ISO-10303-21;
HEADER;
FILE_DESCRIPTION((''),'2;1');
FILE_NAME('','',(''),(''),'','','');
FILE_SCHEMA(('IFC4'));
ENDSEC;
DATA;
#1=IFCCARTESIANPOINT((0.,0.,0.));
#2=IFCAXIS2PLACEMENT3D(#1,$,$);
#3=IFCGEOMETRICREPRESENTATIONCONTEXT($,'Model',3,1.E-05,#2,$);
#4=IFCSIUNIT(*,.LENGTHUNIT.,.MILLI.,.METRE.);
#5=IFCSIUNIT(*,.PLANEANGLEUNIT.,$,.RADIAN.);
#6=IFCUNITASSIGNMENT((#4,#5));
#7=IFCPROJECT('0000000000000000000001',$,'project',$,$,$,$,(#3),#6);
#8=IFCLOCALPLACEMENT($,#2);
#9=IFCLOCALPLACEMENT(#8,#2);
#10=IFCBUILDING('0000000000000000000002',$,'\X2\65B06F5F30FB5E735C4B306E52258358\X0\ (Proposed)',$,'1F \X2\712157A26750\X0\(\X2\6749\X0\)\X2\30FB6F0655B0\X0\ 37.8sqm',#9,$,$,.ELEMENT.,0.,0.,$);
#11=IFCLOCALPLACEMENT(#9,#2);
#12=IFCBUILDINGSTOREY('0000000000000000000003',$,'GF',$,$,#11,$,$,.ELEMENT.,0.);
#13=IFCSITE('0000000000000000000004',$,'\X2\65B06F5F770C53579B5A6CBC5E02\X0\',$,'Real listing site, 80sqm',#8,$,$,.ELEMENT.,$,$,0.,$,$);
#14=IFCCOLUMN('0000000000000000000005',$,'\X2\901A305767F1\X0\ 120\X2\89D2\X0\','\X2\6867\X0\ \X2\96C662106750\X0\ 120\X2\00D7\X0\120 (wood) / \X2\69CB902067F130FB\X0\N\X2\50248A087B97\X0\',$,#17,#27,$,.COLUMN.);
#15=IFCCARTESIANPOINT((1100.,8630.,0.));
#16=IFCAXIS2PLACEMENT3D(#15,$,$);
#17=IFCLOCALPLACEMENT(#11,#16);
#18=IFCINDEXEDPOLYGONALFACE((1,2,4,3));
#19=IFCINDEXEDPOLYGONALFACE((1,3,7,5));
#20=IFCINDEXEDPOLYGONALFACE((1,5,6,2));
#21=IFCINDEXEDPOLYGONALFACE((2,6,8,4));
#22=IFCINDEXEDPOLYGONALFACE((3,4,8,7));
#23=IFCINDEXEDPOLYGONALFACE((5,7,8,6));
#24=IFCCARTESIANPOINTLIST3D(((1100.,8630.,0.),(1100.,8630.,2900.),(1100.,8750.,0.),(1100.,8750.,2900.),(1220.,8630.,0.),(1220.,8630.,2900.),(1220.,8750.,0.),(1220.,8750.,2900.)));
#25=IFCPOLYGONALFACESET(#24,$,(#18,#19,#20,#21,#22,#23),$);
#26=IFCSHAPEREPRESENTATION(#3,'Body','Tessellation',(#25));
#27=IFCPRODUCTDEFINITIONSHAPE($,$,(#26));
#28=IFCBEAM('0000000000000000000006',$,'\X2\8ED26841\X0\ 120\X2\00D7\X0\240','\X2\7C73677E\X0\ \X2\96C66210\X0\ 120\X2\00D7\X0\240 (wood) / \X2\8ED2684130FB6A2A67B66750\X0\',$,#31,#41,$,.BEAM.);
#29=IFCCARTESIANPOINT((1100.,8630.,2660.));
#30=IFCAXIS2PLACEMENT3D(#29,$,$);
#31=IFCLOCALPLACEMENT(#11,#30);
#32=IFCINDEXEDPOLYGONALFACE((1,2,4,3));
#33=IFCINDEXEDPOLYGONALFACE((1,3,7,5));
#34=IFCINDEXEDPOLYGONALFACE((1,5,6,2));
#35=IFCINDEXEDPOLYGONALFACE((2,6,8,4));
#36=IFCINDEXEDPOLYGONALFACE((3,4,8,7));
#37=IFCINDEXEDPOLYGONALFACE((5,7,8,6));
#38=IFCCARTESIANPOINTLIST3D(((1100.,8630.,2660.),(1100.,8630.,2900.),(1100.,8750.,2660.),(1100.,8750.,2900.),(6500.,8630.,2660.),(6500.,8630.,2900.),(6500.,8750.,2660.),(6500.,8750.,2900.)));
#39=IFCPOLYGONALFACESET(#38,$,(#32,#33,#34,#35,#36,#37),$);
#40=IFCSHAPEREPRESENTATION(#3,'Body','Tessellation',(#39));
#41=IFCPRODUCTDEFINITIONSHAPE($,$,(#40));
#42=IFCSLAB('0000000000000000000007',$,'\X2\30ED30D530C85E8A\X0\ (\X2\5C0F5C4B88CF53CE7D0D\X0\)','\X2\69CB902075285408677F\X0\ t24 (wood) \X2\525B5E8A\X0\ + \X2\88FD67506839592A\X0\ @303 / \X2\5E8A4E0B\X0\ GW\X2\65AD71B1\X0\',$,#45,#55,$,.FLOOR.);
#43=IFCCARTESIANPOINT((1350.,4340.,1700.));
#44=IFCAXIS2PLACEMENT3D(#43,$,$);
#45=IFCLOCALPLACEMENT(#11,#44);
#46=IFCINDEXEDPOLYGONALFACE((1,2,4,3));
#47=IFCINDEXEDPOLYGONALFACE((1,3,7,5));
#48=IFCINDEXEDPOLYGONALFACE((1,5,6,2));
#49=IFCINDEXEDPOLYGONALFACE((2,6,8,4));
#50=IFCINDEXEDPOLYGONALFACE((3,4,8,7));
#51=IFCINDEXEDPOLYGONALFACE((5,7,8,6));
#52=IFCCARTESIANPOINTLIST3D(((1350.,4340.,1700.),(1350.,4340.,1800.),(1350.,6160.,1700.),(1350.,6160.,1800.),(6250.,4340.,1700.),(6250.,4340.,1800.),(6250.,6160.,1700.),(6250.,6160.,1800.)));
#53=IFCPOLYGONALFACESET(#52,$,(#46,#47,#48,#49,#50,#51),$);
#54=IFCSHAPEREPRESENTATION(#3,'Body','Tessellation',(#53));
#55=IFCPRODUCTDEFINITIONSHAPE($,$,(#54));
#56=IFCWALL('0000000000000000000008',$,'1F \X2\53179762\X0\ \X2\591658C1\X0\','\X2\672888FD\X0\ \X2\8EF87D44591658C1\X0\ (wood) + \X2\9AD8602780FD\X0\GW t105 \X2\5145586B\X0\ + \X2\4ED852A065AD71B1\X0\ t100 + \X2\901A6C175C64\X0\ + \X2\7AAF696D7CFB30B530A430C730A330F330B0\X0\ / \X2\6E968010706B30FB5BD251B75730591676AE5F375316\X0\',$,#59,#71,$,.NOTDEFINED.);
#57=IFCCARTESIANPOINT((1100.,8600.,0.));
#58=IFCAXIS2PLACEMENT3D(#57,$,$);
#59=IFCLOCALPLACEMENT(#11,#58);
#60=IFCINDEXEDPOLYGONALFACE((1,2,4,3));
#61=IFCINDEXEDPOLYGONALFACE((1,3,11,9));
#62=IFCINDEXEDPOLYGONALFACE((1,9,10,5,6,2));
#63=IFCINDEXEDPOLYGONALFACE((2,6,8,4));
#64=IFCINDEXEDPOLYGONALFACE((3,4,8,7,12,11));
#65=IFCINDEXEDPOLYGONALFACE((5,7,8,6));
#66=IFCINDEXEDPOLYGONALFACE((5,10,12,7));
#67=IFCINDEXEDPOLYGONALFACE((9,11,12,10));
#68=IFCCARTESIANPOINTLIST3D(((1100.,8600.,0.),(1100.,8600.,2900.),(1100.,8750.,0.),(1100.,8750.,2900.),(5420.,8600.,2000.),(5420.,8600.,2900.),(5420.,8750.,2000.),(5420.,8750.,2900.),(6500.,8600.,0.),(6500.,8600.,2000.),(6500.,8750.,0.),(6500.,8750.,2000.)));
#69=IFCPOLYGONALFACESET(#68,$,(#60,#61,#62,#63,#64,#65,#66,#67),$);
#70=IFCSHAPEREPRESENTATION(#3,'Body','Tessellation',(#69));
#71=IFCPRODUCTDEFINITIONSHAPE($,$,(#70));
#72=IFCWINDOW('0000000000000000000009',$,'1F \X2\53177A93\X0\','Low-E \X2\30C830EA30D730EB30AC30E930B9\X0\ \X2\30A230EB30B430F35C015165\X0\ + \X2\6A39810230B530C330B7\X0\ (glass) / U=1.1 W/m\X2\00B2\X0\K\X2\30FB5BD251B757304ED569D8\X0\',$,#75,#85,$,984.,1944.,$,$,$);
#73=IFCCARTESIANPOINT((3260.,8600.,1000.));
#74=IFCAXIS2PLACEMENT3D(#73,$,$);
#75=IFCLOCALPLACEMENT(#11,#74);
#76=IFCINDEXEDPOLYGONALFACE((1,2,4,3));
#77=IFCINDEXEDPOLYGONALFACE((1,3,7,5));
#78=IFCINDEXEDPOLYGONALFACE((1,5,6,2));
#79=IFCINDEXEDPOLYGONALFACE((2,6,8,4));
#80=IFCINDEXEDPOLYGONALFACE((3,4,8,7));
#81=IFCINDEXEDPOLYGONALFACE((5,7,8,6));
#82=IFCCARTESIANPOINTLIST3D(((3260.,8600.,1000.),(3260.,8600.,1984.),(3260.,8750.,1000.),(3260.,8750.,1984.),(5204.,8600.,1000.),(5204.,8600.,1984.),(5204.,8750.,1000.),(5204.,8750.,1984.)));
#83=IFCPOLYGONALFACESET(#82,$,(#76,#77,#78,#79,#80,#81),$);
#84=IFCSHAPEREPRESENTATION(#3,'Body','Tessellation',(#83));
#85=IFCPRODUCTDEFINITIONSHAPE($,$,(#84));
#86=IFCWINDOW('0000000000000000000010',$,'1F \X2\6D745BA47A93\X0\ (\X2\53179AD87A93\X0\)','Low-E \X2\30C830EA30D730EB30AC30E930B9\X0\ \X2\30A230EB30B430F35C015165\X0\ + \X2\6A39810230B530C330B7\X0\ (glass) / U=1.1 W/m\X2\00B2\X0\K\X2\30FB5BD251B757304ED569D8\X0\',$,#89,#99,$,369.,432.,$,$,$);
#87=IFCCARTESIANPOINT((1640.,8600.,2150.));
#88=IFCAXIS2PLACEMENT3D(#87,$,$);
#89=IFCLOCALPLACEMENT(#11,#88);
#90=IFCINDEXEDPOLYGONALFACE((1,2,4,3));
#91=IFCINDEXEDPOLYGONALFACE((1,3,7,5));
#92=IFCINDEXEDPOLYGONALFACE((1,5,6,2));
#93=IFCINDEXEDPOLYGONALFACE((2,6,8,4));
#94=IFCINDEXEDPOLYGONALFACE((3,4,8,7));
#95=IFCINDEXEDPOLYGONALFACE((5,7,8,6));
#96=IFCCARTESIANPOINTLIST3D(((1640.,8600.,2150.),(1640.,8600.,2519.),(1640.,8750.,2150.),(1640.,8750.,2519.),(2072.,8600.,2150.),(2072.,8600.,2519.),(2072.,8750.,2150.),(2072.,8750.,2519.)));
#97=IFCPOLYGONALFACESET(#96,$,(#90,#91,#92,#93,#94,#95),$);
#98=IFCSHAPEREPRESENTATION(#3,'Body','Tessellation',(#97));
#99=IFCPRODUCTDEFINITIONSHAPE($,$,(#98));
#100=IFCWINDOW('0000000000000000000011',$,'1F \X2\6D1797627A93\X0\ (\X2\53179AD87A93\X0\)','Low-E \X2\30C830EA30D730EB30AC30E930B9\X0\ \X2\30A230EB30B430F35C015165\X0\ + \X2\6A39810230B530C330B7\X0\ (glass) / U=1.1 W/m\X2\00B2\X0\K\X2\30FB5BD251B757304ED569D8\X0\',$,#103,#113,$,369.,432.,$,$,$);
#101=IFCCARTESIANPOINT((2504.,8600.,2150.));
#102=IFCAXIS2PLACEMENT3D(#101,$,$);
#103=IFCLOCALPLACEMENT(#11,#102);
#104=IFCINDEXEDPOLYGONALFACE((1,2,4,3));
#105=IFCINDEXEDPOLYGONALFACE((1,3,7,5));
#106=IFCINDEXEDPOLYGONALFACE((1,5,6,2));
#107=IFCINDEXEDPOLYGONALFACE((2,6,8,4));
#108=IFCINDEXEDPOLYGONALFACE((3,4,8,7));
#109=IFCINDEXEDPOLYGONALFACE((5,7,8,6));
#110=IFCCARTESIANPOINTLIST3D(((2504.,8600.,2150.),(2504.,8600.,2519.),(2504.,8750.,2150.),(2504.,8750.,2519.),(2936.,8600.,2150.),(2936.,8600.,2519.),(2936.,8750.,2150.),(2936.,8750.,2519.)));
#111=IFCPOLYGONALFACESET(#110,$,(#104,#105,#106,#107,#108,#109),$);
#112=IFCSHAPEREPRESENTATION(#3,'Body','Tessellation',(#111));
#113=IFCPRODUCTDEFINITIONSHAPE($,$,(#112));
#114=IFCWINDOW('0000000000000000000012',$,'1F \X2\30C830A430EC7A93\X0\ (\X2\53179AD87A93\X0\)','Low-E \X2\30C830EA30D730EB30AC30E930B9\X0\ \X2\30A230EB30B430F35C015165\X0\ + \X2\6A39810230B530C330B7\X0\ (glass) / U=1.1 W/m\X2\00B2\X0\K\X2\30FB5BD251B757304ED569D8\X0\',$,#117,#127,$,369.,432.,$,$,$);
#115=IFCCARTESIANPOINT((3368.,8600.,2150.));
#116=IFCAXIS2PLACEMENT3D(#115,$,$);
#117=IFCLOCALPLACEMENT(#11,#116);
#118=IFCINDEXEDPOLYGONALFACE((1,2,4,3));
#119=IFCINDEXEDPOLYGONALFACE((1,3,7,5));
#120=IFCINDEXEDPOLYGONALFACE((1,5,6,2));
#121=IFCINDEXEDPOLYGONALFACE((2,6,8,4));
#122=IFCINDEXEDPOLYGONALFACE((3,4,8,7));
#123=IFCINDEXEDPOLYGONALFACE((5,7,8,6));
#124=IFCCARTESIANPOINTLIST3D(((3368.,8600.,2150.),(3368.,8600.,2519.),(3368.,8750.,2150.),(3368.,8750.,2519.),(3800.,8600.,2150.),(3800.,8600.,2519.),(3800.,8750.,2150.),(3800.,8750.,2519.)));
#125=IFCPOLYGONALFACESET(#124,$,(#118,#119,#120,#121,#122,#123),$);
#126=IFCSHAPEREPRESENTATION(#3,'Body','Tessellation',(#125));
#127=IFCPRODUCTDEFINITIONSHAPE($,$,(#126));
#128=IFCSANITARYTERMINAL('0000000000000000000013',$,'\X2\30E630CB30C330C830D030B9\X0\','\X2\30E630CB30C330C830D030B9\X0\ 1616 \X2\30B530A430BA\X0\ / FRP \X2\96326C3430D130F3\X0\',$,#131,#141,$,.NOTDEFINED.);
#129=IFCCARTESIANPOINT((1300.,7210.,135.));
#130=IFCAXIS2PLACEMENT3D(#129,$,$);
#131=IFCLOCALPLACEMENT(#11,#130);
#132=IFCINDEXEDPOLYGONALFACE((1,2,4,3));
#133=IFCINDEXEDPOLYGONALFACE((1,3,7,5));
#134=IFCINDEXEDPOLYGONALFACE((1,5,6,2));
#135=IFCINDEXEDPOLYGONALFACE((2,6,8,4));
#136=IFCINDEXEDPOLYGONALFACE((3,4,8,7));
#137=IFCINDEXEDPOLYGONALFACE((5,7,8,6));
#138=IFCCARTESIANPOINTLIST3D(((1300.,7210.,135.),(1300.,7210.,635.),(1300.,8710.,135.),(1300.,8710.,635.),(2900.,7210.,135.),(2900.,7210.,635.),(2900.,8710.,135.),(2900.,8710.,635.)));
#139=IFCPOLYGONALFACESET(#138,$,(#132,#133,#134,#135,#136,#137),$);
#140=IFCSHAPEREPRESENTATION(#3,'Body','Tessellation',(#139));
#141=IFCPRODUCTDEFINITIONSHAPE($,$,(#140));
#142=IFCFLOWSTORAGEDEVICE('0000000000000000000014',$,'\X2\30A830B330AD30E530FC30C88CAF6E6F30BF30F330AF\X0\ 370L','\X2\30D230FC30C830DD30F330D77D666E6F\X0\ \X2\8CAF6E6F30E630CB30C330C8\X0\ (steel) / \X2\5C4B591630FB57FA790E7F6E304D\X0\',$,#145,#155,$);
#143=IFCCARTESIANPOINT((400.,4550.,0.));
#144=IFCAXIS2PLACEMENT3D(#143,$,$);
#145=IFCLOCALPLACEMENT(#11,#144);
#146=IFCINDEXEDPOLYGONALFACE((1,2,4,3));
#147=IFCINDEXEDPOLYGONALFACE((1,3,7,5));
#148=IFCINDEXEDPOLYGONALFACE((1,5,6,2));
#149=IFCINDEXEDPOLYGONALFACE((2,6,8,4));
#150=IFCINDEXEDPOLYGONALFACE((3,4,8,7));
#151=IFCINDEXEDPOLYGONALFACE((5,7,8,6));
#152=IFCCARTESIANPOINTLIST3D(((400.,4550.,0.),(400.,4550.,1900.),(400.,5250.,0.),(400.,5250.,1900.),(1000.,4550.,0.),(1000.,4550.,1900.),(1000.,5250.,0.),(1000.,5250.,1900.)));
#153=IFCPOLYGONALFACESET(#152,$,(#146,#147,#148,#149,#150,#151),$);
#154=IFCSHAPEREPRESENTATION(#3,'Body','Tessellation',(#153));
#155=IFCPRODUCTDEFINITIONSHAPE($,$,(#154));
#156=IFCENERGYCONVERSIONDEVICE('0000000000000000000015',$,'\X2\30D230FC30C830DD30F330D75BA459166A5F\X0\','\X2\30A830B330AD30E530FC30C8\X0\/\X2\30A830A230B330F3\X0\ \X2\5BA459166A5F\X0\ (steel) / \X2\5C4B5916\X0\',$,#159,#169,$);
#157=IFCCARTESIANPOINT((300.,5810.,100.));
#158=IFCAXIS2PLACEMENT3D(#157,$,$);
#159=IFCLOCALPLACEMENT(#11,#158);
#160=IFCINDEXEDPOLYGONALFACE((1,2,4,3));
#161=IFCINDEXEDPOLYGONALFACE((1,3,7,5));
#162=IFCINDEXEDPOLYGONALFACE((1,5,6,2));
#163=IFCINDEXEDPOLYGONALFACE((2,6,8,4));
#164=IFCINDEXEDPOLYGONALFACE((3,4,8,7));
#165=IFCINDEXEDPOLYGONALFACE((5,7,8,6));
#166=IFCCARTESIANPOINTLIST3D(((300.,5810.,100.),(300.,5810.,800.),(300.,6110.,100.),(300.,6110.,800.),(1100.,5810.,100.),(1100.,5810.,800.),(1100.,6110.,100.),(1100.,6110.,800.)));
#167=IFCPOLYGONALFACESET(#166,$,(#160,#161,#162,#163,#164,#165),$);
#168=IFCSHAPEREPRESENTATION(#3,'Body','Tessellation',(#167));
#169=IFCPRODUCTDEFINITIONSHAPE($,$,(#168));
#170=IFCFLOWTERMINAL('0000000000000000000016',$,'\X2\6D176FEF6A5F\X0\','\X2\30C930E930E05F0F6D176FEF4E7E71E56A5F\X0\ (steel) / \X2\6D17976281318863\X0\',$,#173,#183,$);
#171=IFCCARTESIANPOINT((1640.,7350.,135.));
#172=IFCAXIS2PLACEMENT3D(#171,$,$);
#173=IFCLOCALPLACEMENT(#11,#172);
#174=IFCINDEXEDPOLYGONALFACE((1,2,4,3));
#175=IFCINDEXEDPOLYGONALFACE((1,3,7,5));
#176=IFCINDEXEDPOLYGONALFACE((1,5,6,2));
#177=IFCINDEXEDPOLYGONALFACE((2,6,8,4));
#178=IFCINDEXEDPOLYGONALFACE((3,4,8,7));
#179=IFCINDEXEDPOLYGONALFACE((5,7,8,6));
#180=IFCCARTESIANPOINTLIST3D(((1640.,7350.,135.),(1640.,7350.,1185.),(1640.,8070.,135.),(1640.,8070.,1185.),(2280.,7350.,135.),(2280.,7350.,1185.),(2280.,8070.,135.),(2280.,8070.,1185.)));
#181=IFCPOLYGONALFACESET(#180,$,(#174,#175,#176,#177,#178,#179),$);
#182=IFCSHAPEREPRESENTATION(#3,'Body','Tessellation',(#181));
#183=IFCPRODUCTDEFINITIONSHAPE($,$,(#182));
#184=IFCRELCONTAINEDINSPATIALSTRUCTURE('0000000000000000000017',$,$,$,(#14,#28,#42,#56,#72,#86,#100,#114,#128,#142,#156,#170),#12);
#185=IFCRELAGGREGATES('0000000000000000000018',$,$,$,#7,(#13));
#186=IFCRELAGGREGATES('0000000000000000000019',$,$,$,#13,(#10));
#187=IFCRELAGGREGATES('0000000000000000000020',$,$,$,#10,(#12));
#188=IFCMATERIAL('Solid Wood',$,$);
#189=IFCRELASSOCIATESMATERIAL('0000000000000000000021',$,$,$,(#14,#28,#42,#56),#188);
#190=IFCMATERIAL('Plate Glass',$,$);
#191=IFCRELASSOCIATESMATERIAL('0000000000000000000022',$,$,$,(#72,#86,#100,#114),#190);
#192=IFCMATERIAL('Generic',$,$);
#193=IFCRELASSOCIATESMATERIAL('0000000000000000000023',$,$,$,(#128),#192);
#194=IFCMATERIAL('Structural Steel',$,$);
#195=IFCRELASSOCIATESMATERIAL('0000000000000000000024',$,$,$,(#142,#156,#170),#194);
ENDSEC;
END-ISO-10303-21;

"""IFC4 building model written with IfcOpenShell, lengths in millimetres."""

from ifc_helpers import new_model, si_unit, frame, frame_2d, origin, place, context, project, spatial, rectangle, extrude, material, element, fill, save


model = new_model("IFC4")

# Units and contexts
model_context = context("Model", 3, precision=1e-05, world=origin())
ifc_project = project(units=[si_unit("LENGTHUNIT", "METRE", prefix="MILLI"), si_unit("PLANEANGLEUNIT", "RADIAN")], contexts=[model_context])

# Site, building, storey
site_placement = place(None, origin())
site = spatial("IfcSite", under=ifc_project, at=site_placement, Name="新潟県南魚沼市", ObjectType="Real listing site, 80sqm", CompositionType="ELEMENT", RefElevation=0.0)
building_placement = place(site_placement, origin())
building = spatial("IfcBuilding", under=site, at=building_placement, Name="新潟・平屋の別荘 (Proposed)", ObjectType="1F 無垢材(杉)・漆喰 37.8sqm", CompositionType="ELEMENT", ElevationOfRefHeight=0.0, ElevationOfTerrain=0.0)
storey_placement = place(building_placement, origin())
storey = spatial("IfcBuildingStorey", under=building, at=storey_placement, Name="GF", CompositionType="ELEMENT", Elevation=0.0)

# Column
ifc_material_1 = material(Name="Solid Wood")
column_1_placement = place(storey_placement, frame((1100.0, 8630.0, 0.0)))
element("IfcColumn", 1, at=column_1_placement, inside=storey, material=ifc_material_1, Name="通し柱 120角", Description="桧 集成材 120×120 (wood) / 構造柱・N値計算", PredefinedType="COLUMN", context=model_context, shape_type="SweptSolid", body=[
    extrude(rectangle(XDim=120.0, YDim=120.0, at=frame_2d((60.0, 60.0))), frame((1100.0, 8630.0, 0.0)), (0.0, 0.0, 1.0), 2900.0),
])

# Beam
beam_1_placement = place(storey_placement, frame((1100.0, 8630.0, 2660.0)))
element("IfcBeam", 2, at=beam_1_placement, inside=storey, material=ifc_material_1, Name="軒桁 120×240", Description="米松 集成 120×240 (wood) / 軒桁・横架材", PredefinedType="BEAM", context=model_context, shape_type="SweptSolid", body=[
    extrude(rectangle(XDim=5400.0, YDim=120.0, at=frame_2d((2700.0, 60.0))), frame((1100.0, 8630.0, 2660.0)), (0.0, 0.0, 1.0), 240.0),
])

# Slab
slab_placement = place(storey_placement, frame((1350.0, 4340.0, 1700.0)))
element("IfcSlab", 3, at=slab_placement, inside=storey, material=ifc_material_1, Name="ロフト床 (小屋裏収納)", Description="構造用合板 t24 (wood) 剛床 + 製材根太 @303 / 床下 GW断熱", PredefinedType="FLOOR", context=model_context, shape_type="SweptSolid", body=[
    extrude(rectangle(XDim=4900.0, YDim=1820.0, at=frame_2d((2450.0, 910.0))), frame((1350.0, 4340.0, 1700.0)), (0.0, 0.0, 1.0), 100.0),
])

# Wall, openings, windows
wall_1_placement = place(storey_placement, frame((1100.0, 8600.0, 0.0)))
wall_1 = element("IfcWall", 4, at=wall_1_placement, inside=storey, material=ifc_material_1, Name="1F 北面 外壁", Description="木製 軸組外壁 (wood) + 高性能GW t105 充填 + 付加断熱 t100 + 通気層 + 窯業系サイディング / 準耐火・寒冷地外皮強化", PredefinedType="NOTDEFINED", context=model_context, shape_type="SweptSolid", body=[
    extrude(rectangle(XDim=5400.0, YDim=150.0, at=frame_2d((2700.0, 75.0))), frame((1100.0, 8600.0, 0.0)), (0.0, 0.0, 1.0), 2900.0),
])
opening_1_placement = place(storey_placement, frame((3260.0, 8600.0, 1000.0)))
opening_1 = element("IfcOpeningElement", 5, at=opening_1_placement, cuts=wall_1, PredefinedType="NOTDEFINED", context=model_context, shape_type="SweptSolid", body=[
    extrude(rectangle(XDim=1944.0, YDim=150.0, at=frame_2d((972.0, 75.0))), frame((3260.0, 8600.0, 1000.0)), (0.0, 0.0, 1.0), 984.0),
])
opening_2_placement = place(storey_placement, frame((1640.0, 8600.0, 2150.0)))
opening_2 = element("IfcOpeningElement", 6, at=opening_2_placement, cuts=wall_1, PredefinedType="NOTDEFINED", context=model_context, shape_type="SweptSolid", body=[
    extrude(rectangle(XDim=432.0, YDim=150.0, at=frame_2d((216.0, 75.0))), frame((1640.0, 8600.0, 2150.0)), (0.0, 0.0, 1.0), 369.0),
])
opening_3_placement = place(storey_placement, frame((2504.0, 8600.0, 2150.0)))
opening_3 = element("IfcOpeningElement", 7, at=opening_3_placement, cuts=wall_1, PredefinedType="NOTDEFINED", context=model_context, shape_type="SweptSolid", body=[
    extrude(rectangle(XDim=432.0, YDim=150.0, at=frame_2d((216.0, 75.0))), frame((2504.0, 8600.0, 2150.0)), (0.0, 0.0, 1.0), 369.0),
])
opening_4_placement = place(storey_placement, frame((3368.0, 8600.0, 2150.0)))
opening_4 = element("IfcOpeningElement", 8, at=opening_4_placement, cuts=wall_1, PredefinedType="NOTDEFINED", context=model_context, shape_type="SweptSolid", body=[
    extrude(rectangle(XDim=432.0, YDim=150.0, at=frame_2d((216.0, 75.0))), frame((3368.0, 8600.0, 2150.0)), (0.0, 0.0, 1.0), 369.0),
])
ifc_material_2 = material(Name="Plate Glass")
window_1_placement = place(storey_placement, frame((3260.0, 8600.0, 1000.0)))
window_1 = element("IfcWindow", 9, at=window_1_placement, inside=storey, material=ifc_material_2, Name="1F 北窓", Description="Low-E トリプルガラス アルゴン封入 + 樹脂サッシ (glass) / U=1.1 W/m²K・寒冷地仕様", OverallHeight=984.0, OverallWidth=1944.0, context=model_context, shape_type="SweptSolid", body=[
    extrude(rectangle(XDim=1944.0, YDim=150.0, at=frame_2d((972.0, 75.0))), frame((3260.0, 8600.0, 1000.0)), (0.0, 0.0, 1.0), 984.0),
])
fill(opening_1, window_1)
window_2_placement = place(storey_placement, frame((1640.0, 8600.0, 2150.0)))
window_2 = element("IfcWindow", 10, at=window_2_placement, inside=storey, material=ifc_material_2, Name="1F 浴室窓 (北高窓)", Description="Low-E トリプルガラス アルゴン封入 + 樹脂サッシ (glass) / U=1.1 W/m²K・寒冷地仕様", OverallHeight=369.0, OverallWidth=432.0, context=model_context, shape_type="SweptSolid", body=[
    extrude(rectangle(XDim=432.0, YDim=150.0, at=frame_2d((216.0, 75.0))), frame((1640.0, 8600.0, 2150.0)), (0.0, 0.0, 1.0), 369.0),
])
fill(opening_2, window_2)
window_3_placement = place(storey_placement, frame((2504.0, 8600.0, 2150.0)))
window_3 = element("IfcWindow", 11, at=window_3_placement, inside=storey, material=ifc_material_2, Name="1F 洗面窓 (北高窓)", Description="Low-E トリプルガラス アルゴン封入 + 樹脂サッシ (glass) / U=1.1 W/m²K・寒冷地仕様", OverallHeight=369.0, OverallWidth=432.0, context=model_context, shape_type="SweptSolid", body=[
    extrude(rectangle(XDim=432.0, YDim=150.0, at=frame_2d((216.0, 75.0))), frame((2504.0, 8600.0, 2150.0)), (0.0, 0.0, 1.0), 369.0),
])
fill(opening_3, window_3)
window_4_placement = place(storey_placement, frame((3368.0, 8600.0, 2150.0)))
window_4 = element("IfcWindow", 12, at=window_4_placement, inside=storey, material=ifc_material_2, Name="1F トイレ窓 (北高窓)", Description="Low-E トリプルガラス アルゴン封入 + 樹脂サッシ (glass) / U=1.1 W/m²K・寒冷地仕様", OverallHeight=369.0, OverallWidth=432.0, context=model_context, shape_type="SweptSolid", body=[
    extrude(rectangle(XDim=432.0, YDim=150.0, at=frame_2d((216.0, 75.0))), frame((3368.0, 8600.0, 2150.0)), (0.0, 0.0, 1.0), 369.0),
])
fill(opening_4, window_4)

# Sanitary terminal
ifc_material_3 = material(Name="Generic")
sanitary_terminal_placement = place(storey_placement, frame((1300.0, 7210.0, 135.0)))
element("IfcSanitaryTerminal", 13, at=sanitary_terminal_placement, inside=storey, material=ifc_material_3, Name="ユニットバス", Description="ユニットバス 1616 サイズ / FRP 防水パン", PredefinedType="NOTDEFINED", context=model_context, shape_type="SweptSolid", body=[
    extrude(rectangle(XDim=1600.0, YDim=1500.0, at=frame_2d((800.0, 750.0))), frame((1300.0, 7210.0, 135.0)), (0.0, 0.0, 1.0), 500.0),
])

# Flow storage device
ifc_material_4 = material(Name="Structural Steel")
flow_storage_device_placement = place(storey_placement, frame((400.0, 4550.0, 0.0)))
element("IfcFlowStorageDevice", 14, at=flow_storage_device_placement, inside=storey, material=ifc_material_4, Name="エコキュート貯湯タンク 370L", Description="ヒートポンプ給湯 貯湯ユニット (steel) / 屋外・基礎置き", context=model_context, shape_type="SweptSolid", body=[
    extrude(rectangle(XDim=600.0, YDim=700.0, at=frame_2d((300.0, 350.0))), frame((400.0, 4550.0, 0.0)), (0.0, 0.0, 1.0), 1900.0),
])

# Energy conversion device
energy_conversion_device_placement = place(storey_placement, frame((300.0, 5810.0, 100.0)))
element("IfcEnergyConversionDevice", 15, at=energy_conversion_device_placement, inside=storey, material=ifc_material_4, Name="ヒートポンプ室外機", Description="エコキュート/エアコン 室外機 (steel) / 屋外", context=model_context, shape_type="SweptSolid", body=[
    extrude(rectangle(XDim=800.0, YDim=300.0, at=frame_2d((400.0, 150.0))), frame((300.0, 5810.0, 100.0)), (0.0, 0.0, 1.0), 700.0),
])

# Flow terminal
flow_terminal_placement = place(storey_placement, frame((1640.0, 7350.0, 135.0)))
element("IfcFlowTerminal", 16, at=flow_terminal_placement, inside=storey, material=ifc_material_4, Name="洗濯機", Description="ドラム式洗濯乾燥機 (steel) / 洗面脱衣", context=model_context, shape_type="SweptSolid", body=[
    extrude(rectangle(XDim=640.0, YDim=720.0, at=frame_2d((320.0, 360.0))), frame((1640.0, 7350.0, 135.0)), (0.0, 0.0, 1.0), 1050.0),
])

save(model, "model.ifc")
